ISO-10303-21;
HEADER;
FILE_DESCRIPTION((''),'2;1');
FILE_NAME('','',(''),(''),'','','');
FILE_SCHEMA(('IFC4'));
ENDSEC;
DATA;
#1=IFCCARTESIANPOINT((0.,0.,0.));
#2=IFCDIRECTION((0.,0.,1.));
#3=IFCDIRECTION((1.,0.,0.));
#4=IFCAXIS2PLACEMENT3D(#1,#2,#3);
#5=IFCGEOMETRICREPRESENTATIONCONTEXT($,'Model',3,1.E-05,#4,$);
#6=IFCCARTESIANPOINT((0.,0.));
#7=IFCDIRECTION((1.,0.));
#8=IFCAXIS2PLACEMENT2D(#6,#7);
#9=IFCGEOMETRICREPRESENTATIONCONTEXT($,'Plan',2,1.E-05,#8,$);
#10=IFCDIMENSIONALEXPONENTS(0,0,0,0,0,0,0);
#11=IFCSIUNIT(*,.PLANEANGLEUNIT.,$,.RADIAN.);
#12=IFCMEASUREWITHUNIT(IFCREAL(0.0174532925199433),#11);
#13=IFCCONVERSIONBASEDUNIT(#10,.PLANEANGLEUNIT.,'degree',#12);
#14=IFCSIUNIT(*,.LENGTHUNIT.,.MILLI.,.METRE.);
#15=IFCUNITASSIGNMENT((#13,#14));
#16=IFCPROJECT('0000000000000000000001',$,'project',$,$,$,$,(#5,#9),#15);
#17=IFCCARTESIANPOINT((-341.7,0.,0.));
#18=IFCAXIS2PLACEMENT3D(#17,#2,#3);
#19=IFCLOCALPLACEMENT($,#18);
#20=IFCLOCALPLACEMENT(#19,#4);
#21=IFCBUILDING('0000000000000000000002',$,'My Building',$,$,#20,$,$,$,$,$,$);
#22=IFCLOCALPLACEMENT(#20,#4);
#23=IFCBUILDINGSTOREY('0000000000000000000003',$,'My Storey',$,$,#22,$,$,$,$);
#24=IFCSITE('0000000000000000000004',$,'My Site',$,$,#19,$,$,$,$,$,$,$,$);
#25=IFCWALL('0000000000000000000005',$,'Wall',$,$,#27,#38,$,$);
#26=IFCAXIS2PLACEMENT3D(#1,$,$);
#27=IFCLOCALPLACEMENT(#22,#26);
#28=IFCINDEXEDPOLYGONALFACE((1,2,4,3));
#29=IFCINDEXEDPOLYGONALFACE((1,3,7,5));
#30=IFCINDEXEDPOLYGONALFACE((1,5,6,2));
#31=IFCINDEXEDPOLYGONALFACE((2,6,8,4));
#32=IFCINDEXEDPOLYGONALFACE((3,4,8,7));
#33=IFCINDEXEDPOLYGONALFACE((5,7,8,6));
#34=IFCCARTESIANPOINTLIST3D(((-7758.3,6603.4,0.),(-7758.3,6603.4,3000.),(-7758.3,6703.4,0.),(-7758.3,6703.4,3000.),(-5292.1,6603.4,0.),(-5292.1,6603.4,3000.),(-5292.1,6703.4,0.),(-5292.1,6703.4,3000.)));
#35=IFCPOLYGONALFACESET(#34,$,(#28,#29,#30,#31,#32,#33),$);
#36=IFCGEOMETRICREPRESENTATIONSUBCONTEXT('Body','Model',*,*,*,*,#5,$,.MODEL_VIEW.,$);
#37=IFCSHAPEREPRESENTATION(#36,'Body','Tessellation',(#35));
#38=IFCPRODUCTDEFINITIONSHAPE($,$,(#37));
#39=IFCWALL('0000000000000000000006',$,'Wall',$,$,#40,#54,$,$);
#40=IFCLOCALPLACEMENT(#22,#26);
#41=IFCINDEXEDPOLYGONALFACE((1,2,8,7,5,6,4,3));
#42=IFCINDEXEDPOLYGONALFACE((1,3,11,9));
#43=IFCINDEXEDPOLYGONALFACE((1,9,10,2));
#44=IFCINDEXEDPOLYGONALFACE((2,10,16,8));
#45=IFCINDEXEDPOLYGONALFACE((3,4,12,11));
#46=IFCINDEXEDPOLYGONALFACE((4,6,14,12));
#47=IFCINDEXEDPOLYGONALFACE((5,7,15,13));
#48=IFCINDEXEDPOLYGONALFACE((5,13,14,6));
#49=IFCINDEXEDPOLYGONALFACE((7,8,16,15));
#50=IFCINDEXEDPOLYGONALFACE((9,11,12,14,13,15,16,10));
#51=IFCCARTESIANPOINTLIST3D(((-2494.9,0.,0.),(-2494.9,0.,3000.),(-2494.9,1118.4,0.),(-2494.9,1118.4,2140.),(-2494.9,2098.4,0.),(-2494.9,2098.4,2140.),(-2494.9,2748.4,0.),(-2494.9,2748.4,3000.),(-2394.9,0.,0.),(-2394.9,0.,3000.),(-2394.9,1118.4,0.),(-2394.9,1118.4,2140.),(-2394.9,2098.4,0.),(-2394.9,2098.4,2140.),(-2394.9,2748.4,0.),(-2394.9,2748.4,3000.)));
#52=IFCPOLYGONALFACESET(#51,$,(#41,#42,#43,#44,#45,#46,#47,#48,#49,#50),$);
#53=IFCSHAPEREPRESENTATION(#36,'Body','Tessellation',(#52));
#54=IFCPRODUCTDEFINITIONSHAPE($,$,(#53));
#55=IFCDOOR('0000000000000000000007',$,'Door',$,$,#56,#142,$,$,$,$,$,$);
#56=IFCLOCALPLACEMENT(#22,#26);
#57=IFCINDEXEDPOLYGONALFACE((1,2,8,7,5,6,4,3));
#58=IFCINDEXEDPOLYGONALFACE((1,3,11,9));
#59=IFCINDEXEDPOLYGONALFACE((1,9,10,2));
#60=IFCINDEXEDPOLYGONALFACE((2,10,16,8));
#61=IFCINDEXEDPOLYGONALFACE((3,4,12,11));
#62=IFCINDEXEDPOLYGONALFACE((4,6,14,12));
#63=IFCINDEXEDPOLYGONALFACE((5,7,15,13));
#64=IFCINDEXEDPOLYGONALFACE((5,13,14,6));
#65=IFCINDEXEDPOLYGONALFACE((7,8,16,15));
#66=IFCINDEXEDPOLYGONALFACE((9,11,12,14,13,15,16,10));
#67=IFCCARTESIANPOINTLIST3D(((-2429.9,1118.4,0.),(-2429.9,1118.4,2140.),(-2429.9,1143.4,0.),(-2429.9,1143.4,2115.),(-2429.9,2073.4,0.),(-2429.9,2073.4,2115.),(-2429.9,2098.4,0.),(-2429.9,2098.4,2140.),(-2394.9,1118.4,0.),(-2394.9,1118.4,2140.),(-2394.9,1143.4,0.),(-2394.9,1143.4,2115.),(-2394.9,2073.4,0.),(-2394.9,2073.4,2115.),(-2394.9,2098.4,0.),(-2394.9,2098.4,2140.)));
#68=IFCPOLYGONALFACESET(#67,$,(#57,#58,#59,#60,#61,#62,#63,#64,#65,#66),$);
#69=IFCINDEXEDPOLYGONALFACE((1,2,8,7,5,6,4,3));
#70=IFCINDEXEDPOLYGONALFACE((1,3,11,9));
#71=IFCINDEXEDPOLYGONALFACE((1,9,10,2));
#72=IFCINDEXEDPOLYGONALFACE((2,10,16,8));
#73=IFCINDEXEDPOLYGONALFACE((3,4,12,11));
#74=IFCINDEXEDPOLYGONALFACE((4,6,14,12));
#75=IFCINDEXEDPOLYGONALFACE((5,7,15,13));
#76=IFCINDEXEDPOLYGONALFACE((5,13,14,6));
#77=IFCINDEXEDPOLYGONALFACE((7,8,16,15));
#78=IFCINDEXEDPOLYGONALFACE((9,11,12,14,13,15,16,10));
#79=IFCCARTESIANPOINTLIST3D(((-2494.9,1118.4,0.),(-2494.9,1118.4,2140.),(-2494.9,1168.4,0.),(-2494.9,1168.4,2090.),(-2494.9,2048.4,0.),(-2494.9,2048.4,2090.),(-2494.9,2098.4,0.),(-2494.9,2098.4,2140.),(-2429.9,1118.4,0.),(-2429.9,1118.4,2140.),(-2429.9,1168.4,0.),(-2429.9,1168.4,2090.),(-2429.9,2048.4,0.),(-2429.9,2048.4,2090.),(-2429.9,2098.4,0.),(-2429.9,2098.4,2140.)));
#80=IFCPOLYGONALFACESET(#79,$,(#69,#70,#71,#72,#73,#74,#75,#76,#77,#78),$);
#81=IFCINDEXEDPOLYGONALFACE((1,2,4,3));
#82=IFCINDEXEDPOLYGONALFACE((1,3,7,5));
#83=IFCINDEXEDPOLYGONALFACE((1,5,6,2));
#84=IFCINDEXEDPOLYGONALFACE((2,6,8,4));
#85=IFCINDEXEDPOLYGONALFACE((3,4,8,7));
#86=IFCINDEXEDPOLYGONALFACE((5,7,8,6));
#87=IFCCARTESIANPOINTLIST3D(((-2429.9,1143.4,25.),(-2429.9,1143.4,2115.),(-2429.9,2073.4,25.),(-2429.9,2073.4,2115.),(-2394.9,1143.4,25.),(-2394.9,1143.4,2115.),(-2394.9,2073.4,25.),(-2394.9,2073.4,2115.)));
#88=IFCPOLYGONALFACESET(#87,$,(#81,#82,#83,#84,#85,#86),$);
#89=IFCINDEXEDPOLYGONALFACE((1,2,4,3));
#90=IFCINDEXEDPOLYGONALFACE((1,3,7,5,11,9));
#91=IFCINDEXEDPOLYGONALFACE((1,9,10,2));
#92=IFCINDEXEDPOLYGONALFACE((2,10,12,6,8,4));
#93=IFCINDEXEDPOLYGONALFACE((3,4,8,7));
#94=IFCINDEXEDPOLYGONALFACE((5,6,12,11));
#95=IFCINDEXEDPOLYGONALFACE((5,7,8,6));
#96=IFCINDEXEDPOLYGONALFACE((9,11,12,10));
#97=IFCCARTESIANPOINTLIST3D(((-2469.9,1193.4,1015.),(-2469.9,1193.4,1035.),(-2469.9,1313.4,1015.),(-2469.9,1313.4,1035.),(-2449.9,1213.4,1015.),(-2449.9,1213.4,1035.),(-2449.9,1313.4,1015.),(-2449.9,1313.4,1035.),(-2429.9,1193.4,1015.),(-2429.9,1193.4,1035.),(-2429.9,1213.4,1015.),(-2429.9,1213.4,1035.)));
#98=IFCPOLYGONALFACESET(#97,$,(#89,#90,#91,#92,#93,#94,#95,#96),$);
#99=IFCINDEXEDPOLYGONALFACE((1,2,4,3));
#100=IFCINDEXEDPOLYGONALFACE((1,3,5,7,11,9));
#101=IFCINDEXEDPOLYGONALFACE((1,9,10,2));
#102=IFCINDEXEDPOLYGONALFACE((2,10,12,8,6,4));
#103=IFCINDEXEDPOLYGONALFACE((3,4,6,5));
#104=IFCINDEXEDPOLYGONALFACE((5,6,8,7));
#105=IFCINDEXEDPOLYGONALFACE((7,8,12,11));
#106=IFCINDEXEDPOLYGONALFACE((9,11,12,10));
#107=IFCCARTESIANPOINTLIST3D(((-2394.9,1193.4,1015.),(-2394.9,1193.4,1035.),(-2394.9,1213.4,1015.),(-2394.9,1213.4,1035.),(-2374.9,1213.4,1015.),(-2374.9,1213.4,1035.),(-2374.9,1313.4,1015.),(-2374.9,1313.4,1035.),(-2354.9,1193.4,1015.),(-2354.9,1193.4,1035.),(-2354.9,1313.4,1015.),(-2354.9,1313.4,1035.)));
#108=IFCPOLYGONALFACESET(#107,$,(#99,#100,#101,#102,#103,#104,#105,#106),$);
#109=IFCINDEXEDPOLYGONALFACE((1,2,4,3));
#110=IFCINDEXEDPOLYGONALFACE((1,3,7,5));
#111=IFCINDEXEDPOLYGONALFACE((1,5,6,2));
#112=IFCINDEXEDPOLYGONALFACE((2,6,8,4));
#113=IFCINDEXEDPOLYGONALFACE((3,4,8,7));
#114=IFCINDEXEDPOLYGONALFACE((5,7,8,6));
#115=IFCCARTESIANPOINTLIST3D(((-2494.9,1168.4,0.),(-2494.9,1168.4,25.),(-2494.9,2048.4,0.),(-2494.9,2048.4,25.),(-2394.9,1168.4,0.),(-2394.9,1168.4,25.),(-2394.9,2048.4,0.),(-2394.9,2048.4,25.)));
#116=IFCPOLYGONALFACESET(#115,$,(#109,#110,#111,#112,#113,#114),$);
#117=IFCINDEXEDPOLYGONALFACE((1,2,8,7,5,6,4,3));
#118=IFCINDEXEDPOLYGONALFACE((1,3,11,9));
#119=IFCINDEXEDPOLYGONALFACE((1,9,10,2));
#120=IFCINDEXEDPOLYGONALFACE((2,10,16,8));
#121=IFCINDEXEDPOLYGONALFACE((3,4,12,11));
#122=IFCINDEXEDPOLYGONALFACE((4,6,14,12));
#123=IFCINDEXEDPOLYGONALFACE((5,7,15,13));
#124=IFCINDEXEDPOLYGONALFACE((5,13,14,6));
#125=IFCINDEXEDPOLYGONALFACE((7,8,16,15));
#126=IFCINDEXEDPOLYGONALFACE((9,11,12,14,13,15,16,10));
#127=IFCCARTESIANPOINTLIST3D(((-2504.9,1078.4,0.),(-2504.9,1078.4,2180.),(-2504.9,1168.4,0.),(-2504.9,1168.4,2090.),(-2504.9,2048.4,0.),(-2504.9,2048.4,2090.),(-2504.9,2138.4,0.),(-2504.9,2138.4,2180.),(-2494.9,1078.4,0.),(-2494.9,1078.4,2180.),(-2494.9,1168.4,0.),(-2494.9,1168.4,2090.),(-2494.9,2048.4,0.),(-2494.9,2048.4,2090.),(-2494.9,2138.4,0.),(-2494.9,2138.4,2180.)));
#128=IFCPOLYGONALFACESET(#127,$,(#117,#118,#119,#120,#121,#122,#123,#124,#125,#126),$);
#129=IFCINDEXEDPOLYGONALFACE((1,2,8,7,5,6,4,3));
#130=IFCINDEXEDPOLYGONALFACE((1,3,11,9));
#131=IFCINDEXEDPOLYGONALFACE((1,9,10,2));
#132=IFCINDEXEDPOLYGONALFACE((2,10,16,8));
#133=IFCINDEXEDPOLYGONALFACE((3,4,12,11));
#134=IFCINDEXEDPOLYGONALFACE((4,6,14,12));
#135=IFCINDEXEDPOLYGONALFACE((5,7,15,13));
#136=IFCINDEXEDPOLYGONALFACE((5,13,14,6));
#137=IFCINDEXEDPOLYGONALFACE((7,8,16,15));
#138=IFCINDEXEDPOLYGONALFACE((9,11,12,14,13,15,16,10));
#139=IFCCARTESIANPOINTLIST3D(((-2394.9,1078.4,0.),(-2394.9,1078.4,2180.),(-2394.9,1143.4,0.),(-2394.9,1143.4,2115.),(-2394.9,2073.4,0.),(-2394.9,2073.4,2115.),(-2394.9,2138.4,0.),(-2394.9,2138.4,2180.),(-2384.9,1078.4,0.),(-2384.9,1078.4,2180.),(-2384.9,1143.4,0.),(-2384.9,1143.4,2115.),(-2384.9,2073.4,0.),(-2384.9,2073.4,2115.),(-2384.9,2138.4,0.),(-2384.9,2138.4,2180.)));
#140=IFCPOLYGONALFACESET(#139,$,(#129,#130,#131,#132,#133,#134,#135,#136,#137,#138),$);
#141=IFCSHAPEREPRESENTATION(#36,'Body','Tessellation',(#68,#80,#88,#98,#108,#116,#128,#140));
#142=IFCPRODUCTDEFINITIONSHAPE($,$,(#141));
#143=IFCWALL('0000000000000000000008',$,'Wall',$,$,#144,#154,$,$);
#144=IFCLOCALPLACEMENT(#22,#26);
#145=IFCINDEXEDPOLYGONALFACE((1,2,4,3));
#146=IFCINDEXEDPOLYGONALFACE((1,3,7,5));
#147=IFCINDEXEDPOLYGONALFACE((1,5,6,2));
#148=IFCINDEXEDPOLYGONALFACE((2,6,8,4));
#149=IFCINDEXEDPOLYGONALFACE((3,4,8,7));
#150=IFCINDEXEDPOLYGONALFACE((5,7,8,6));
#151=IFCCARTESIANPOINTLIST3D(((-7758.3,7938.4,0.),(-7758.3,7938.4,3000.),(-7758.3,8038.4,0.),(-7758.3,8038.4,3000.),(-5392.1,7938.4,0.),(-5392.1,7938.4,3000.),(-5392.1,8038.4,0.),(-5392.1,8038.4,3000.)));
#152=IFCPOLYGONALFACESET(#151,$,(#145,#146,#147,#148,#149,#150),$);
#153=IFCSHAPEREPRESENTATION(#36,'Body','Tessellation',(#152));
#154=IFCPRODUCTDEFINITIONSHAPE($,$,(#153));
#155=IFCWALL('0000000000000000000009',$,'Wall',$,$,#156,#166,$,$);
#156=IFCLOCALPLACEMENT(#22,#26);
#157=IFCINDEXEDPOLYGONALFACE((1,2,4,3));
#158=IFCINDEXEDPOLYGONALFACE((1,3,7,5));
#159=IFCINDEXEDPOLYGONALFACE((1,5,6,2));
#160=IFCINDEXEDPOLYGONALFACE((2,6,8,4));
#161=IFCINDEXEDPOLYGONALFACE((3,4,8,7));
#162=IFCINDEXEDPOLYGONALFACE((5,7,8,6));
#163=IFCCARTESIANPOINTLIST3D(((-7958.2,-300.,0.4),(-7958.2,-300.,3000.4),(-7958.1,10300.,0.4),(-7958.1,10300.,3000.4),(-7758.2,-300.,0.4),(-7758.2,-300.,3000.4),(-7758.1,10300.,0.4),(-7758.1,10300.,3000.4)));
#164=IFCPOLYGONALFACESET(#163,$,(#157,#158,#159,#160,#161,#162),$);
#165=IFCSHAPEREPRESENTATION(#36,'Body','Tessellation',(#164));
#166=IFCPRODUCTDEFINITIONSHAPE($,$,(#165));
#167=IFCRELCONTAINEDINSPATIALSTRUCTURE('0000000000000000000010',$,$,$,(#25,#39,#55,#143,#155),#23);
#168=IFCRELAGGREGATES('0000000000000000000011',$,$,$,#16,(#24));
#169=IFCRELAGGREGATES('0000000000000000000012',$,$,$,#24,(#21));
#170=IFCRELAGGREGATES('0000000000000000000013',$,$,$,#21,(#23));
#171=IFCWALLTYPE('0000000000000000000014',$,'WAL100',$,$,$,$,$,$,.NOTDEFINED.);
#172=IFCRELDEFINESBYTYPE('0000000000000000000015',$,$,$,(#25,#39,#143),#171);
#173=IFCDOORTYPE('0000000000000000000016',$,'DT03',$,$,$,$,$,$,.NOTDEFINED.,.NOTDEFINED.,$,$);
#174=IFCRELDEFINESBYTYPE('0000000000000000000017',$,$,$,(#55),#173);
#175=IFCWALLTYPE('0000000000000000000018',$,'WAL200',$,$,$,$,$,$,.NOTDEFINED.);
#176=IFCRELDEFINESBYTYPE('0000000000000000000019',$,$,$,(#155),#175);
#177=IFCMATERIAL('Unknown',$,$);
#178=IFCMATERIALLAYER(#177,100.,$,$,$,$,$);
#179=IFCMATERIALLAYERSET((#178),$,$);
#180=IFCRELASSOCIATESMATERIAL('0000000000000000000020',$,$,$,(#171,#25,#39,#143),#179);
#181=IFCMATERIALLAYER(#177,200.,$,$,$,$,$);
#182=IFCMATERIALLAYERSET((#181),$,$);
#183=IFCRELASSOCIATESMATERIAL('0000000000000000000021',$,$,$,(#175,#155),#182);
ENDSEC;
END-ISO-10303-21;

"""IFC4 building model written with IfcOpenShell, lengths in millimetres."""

from ifc_helpers import new_model, entity, si_unit, converted_unit, frame, origin_with_axes, origin_2d_with_axis, place, context, subcontext, project, spatial, line, indexed_curve, outline, extrude, shape, source, transform, mapped, material, layer, layer_set, layer_usage, type_object, type_shapes, element, fill, save


model = new_model("IFC4")

# Units and contexts
model_context = context("Model", 3, precision=1e-05, world=origin_with_axes())
plan_context = context("Plan", 2, precision=1e-05, world=origin_2d_with_axis())
body_context_1 = subcontext(model_context, "Body", "Model", "MODEL_VIEW")
body_context_2 = subcontext(plan_context, "Body", "Plan", "PLAN_VIEW")
ifc_project = project(units=[converted_unit("PLANEANGLEUNIT", "degree", entity("IfcReal", 0.0174532925199433), si_unit("PLANEANGLEUNIT", "RADIAN"), dimensions=[0, 0, 0, 0, 0, 0, 0]), si_unit("LENGTHUNIT", "METRE", prefix="MILLI")], contexts=[model_context, plan_context])

# Site, building, storey
site_placement = place(None, frame((-341.7, 0.0, 0.0), z_axis=(0.0, 0.0, 1.0), x_axis=(1.0, 0.0, 0.0)))
site = spatial("IfcSite", under=ifc_project, at=site_placement, Name="My Site")
building_placement = place(site_placement, origin_with_axes())
building = spatial("IfcBuilding", under=site, at=building_placement, Name="My Building")
storey_placement = place(building_placement, origin_with_axes())
storey = spatial("IfcBuildingStorey", under=building, at=storey_placement, Name="My Storey")

# Wall
ifc_material = material(Name="Unknown")
ifc_layer_1 = layer(ifc_material, 100.0)
ifc_layer_set_1 = layer_set([ifc_layer_1])
ifc_layer_usage_1 = layer_usage(ifc_layer_set_1, "AXIS2", "POSITIVE", 0.0)
wall_type_1 = type_object("IfcWallType", Name="WAL100", PredefinedType="NOTDEFINED", material=ifc_layer_set_1)
wall_1_placement = place(storey_placement, frame((-7758.3, 6603.4, 0.0), z_axis=(0.0, 0.0, 1.0), x_axis=(1.0, 0.0, 0.0)))
element("IfcWall", 1, at=wall_1_placement, inside=storey, type_object=wall_type_1, material=ifc_layer_usage_1, Name="Wall", context=body_context_1, shape_type="SweptSolid", body=[
    extrude(outline(indexed_curve([(0.0, 0.0), (0.0, 100.0), (2466.2, 100.0), (2466.2, 0.0), (0.0, 0.0)], self_intersect=False)), origin_with_axes(), (0.0, 0.0, 1.0), 3000.0),
])

# Wall, opening, door
ifc_layer_usage_2 = layer_usage(ifc_layer_set_1, "AXIS2", "POSITIVE", 0.0)
wall_2_placement = place(storey_placement, frame((-2494.9, 2748.4, 0.0), z_axis=(0.0, 0.0, 1.0), x_axis=(0.0, -1.0, 0.0)))
wall_2 = element("IfcWall", 2, at=wall_2_placement, inside=storey, type_object=wall_type_1, material=ifc_layer_usage_2, Name="Wall", context=body_context_1, shape_type="SweptSolid", body=[
    extrude(outline(indexed_curve([(0.0, 0.0), (0.0, 100.0), (2748.4, 100.0), (2748.4, 0.0), (0.0, 0.0)], self_intersect=False)), origin_with_axes(), (0.0, 0.0, 1.0), 3000.0),
])
shared_shape_1 = source(origin_with_axes(), body_context_1, "Body", "SweptSolid", [
    extrude(outline(indexed_curve([(0.0, 0.0), (980.0, 0.0), (980.0, 2140.0), (0.0, 2140.0)], segments=[line(1, 2, 3, 4, 1)])), frame((0.0, -100.0, 0.0), z_axis=(0.0, -1.0, 0.0), x_axis=(1.0, 0.0, 0.0)), (0.0, 0.0, -1.0), 300.0),
])
opening_1_placement = place(wall_2_placement, frame((650.0, 0.0, 0.0), z_axis=(0.0, 0.0, 1.0), x_axis=(1.0, 0.0, 0.0)))
opening_1 = element("IfcOpeningElement", 3, at=opening_1_placement, cuts=wall_2, PredefinedType="OPENING", context=body_context_1, shape_type="MappedRepresentation", body=[
    mapped(shared_shape_1, transform((0.0, 0.0, 0.0), x_axis=(1.0, 0.0, 0.0), y_axis=(0.0, 1.0, 0.0), z_axis=(0.0, 0.0, 1.0), scale=1.0)),
])
door_type_1 = type_object("IfcDoorType", Name="DT03", OperationType="NOTDEFINED", PredefinedType="NOTDEFINED")
shared_shape_2 = source(origin_with_axes(), body_context_1, "Body", "SweptSolid", [
    extrude(outline(indexed_curve([(0.0, 0.0), (0.0, 2140.0), (980.0, 2140.0), (980.0, 0.0), (955.0, 0.0), (955.0, 2115.0), (25.0, 2115.0), (25.0, 0.0)], segments=[line(1, 2, 3, 4, 5, 6, 7, 8, 1)])), frame((0.0, 65.0, 0.0), z_axis=(0.0, -1.0, 0.0), x_axis=(1.0, 0.0, 0.0)), (0.0, 0.0, -1.0), 35.0),
    extrude(outline(indexed_curve([(0.0, 0.0), (0.0, 2140.0), (980.0, 2140.0), (980.0, 0.0), (930.0, 0.0), (930.0, 2090.0), (50.0, 2090.0), (50.0, 0.0)], segments=[line(1, 2, 3, 4, 5, 6, 7, 8, 1)])), frame((0.0, 0.0, 0.0), z_axis=(0.0, -1.0, 0.0), x_axis=(1.0, 0.0, 0.0)), (0.0, 0.0, -1.0), 65.0),
    extrude(outline(indexed_curve([(0.0, 0.0), (930.0, 0.0), (930.0, 35.0), (0.0, 35.0)], segments=[line(1, 2, 3, 4, 1)])), frame((25.0, 65.0, 25.0), z_axis=(0.0, 0.0, 1.0), x_axis=(1.0, 0.0, 0.0)), (0.0, 0.0, 1.0), 2090.0),
    extrude(outline(indexed_curve([(0.0, 0.0), (0.0, -40.0), (-120.0, -40.0), (-120.0, -20.0), (-20.0, -20.0), (-20.0, 0.0)], segments=[line(1, 2, 3, 4, 5, 6, 1)])), frame((905.0, 65.0, 1015.0), z_axis=(0.0, 0.0, 1.0), x_axis=(1.0, 0.0, 0.0)), (0.0, 0.0, 1.0), 20.0),
    extrude(outline(indexed_curve([(0.0, 0.0), (0.0, 40.0), (-120.0, 40.0), (-120.0, 20.0), (-20.0, 20.0), (-20.0, 0.0)], segments=[line(1, 2, 3, 4, 5, 6, 1)])), frame((905.0, 100.0, 1015.0), z_axis=(0.0, 0.0, 1.0), x_axis=(1.0, 0.0, 0.0)), (0.0, 0.0, 1.0), 20.0),
    extrude(outline(indexed_curve([(0.0, 0.0), (880.0, 0.0), (880.0, 100.0), (0.0, 100.0)], segments=[line(1, 2, 3, 4, 1)])), frame((50.0, 0.0, 0.0), z_axis=(0.0, 0.0, 1.0), x_axis=(1.0, 0.0, 0.0)), (0.0, 0.0, 1.0), 25.0),
    extrude(outline(indexed_curve([(0.0, 0.0), (0.0, 2180.0), (1060.0, 2180.0), (1060.0, 0.0), (970.0, 0.0), (970.0, 2090.0), (90.0, 2090.0), (90.0, 0.0)], segments=[line(1, 2, 3, 4, 5, 6, 7, 8, 1)])), frame((-40.0, -10.0, 0.0), z_axis=(0.0, -1.0, 0.0), x_axis=(1.0, 0.0, 0.0)), (0.0, 0.0, -1.0), 10.0),
    extrude(outline(indexed_curve([(0.0, 0.0), (0.0, 2180.0), (1060.0, 2180.0), (1060.0, 0.0), (995.0, 0.0), (995.0, 2115.0), (65.0, 2115.0), (65.0, 0.0)], segments=[line(1, 2, 3, 4, 5, 6, 7, 8, 1)])), frame((-40.0, 100.0, 0.0), z_axis=(0.0, -1.0, 0.0), x_axis=(1.0, 0.0, 0.0)), (0.0, 0.0, -1.0), 10.0),
])
shared_shape_3 = source(origin_with_axes(), body_context_2, "Body", "Curve2D", [
    entity("IfcIndexedPolyCurve", entity("IfcCartesianPointList2D", [[0.0, 0.0], [0.0, 100.0], [25.0, 100.0], [25.0, 65.0], [50.0, 65.0], [50.0, 0.0]]), [entity("IfcLineIndex", [1, 2, 3, 4, 5, 6, 1])]),
    entity("IfcIndexedPolyCurve", entity("IfcCartesianPointList2D", [[980.0, 0.0], [980.0, 100.0], [955.0, 100.0], [955.0, 65.0], [930.0, 65.0], [930.0, 0.0]]), [entity("IfcLineIndex", [1, 2, 3, 4, 5, 6, 1])]),
    entity("IfcTrimmedCurve", entity("IfcEllipse", entity("IfcAxis2Placement2D", entity("IfcCartesianPoint", [60.0, 100.0]), entity("IfcDirection", [1.0, 0.0])), 895.0, 930.0), [entity("IfcCartesianPoint", [955.0, 100.0])], [entity("IfcCartesianPoint", [60.0, 1030.0])], True, "CARTESIAN"),
    entity("IfcIndexedPolyCurve", entity("IfcCartesianPointList2D", [[25.0, 100.0], [60.0, 100.0], [60.0, 1030.0], [25.0, 1030.0]]), [entity("IfcLineIndex", [1, 2, 3, 4, 1])]),
])
type_shapes(door_type_1, [shared_shape_2, shared_shape_3])
door_1_placement = place(opening_1_placement, origin_with_axes())
door_1 = element("IfcDoor", 4, at=door_1_placement, inside=storey, type_object=door_type_1, Name="Door", shapes=[
    shape(body_context_1, "Body", "MappedRepresentation", [mapped(shared_shape_2, transform((0.0, 0.0, 0.0), x_axis=(1.0, 0.0, 0.0), y_axis=(0.0, 1.0, 0.0), z_axis=(0.0, 0.0, 1.0), scale=1.0))]),
    shape(body_context_2, "Body", "MappedRepresentation", [mapped(shared_shape_3, transform((0.0, 0.0, 0.0), x_axis=(1.0, 0.0, 0.0), y_axis=(0.0, 1.0, 0.0), z_axis=(0.0, 0.0, 1.0), scale=1.0))]),
])
fill(opening_1, door_1)

# Wall
ifc_layer_usage_3 = layer_usage(ifc_layer_set_1, "AXIS2", "POSITIVE", 0.0)
wall_3_placement = place(storey_placement, frame((-7758.3, 7938.4, 0.0), z_axis=(0.0, 0.0, 1.0), x_axis=(1.0, 0.0, 0.0)))
element("IfcWall", 5, at=wall_3_placement, inside=storey, type_object=wall_type_1, material=ifc_layer_usage_3, Name="Wall", context=body_context_1, shape_type="SweptSolid", body=[
    extrude(outline(indexed_curve([(0.0, 0.0), (0.0, 100.0), (2366.2, 100.0), (2366.2, 0.0), (0.0, 0.0)], self_intersect=False)), origin_with_axes(), (0.0, 0.0, 1.0), 3000.0),
])

# Wall
ifc_layer_2 = layer(ifc_material, 200.0)
ifc_layer_set_2 = layer_set([ifc_layer_2])
ifc_layer_usage_4 = layer_usage(ifc_layer_set_2, "AXIS2", "POSITIVE", 0.0)
wall_type_2 = type_object("IfcWallType", Name="WAL200", PredefinedType="NOTDEFINED", material=ifc_layer_set_2)
wall_4_placement = place(storey_placement, frame((-7758.2, -300.0, 0.4), z_axis=(0.0, 0.0, 1.0), x_axis=(0.000002, 1.0, 0.0)))
element("IfcWall", 6, at=wall_4_placement, inside=storey, type_object=wall_type_2, material=ifc_layer_usage_4, Name="Wall", context=body_context_1, shape_type="SweptSolid", body=[
    extrude(outline(indexed_curve([(0.0, 0.0), (0.0, 200.0), (10600.0, 200.0), (10600.0, 0.0), (0.0, 0.0)], self_intersect=False)), origin_with_axes(), (0.0, 0.0, 1.0), 3000.0),
])

save(model, "model.ifc")
